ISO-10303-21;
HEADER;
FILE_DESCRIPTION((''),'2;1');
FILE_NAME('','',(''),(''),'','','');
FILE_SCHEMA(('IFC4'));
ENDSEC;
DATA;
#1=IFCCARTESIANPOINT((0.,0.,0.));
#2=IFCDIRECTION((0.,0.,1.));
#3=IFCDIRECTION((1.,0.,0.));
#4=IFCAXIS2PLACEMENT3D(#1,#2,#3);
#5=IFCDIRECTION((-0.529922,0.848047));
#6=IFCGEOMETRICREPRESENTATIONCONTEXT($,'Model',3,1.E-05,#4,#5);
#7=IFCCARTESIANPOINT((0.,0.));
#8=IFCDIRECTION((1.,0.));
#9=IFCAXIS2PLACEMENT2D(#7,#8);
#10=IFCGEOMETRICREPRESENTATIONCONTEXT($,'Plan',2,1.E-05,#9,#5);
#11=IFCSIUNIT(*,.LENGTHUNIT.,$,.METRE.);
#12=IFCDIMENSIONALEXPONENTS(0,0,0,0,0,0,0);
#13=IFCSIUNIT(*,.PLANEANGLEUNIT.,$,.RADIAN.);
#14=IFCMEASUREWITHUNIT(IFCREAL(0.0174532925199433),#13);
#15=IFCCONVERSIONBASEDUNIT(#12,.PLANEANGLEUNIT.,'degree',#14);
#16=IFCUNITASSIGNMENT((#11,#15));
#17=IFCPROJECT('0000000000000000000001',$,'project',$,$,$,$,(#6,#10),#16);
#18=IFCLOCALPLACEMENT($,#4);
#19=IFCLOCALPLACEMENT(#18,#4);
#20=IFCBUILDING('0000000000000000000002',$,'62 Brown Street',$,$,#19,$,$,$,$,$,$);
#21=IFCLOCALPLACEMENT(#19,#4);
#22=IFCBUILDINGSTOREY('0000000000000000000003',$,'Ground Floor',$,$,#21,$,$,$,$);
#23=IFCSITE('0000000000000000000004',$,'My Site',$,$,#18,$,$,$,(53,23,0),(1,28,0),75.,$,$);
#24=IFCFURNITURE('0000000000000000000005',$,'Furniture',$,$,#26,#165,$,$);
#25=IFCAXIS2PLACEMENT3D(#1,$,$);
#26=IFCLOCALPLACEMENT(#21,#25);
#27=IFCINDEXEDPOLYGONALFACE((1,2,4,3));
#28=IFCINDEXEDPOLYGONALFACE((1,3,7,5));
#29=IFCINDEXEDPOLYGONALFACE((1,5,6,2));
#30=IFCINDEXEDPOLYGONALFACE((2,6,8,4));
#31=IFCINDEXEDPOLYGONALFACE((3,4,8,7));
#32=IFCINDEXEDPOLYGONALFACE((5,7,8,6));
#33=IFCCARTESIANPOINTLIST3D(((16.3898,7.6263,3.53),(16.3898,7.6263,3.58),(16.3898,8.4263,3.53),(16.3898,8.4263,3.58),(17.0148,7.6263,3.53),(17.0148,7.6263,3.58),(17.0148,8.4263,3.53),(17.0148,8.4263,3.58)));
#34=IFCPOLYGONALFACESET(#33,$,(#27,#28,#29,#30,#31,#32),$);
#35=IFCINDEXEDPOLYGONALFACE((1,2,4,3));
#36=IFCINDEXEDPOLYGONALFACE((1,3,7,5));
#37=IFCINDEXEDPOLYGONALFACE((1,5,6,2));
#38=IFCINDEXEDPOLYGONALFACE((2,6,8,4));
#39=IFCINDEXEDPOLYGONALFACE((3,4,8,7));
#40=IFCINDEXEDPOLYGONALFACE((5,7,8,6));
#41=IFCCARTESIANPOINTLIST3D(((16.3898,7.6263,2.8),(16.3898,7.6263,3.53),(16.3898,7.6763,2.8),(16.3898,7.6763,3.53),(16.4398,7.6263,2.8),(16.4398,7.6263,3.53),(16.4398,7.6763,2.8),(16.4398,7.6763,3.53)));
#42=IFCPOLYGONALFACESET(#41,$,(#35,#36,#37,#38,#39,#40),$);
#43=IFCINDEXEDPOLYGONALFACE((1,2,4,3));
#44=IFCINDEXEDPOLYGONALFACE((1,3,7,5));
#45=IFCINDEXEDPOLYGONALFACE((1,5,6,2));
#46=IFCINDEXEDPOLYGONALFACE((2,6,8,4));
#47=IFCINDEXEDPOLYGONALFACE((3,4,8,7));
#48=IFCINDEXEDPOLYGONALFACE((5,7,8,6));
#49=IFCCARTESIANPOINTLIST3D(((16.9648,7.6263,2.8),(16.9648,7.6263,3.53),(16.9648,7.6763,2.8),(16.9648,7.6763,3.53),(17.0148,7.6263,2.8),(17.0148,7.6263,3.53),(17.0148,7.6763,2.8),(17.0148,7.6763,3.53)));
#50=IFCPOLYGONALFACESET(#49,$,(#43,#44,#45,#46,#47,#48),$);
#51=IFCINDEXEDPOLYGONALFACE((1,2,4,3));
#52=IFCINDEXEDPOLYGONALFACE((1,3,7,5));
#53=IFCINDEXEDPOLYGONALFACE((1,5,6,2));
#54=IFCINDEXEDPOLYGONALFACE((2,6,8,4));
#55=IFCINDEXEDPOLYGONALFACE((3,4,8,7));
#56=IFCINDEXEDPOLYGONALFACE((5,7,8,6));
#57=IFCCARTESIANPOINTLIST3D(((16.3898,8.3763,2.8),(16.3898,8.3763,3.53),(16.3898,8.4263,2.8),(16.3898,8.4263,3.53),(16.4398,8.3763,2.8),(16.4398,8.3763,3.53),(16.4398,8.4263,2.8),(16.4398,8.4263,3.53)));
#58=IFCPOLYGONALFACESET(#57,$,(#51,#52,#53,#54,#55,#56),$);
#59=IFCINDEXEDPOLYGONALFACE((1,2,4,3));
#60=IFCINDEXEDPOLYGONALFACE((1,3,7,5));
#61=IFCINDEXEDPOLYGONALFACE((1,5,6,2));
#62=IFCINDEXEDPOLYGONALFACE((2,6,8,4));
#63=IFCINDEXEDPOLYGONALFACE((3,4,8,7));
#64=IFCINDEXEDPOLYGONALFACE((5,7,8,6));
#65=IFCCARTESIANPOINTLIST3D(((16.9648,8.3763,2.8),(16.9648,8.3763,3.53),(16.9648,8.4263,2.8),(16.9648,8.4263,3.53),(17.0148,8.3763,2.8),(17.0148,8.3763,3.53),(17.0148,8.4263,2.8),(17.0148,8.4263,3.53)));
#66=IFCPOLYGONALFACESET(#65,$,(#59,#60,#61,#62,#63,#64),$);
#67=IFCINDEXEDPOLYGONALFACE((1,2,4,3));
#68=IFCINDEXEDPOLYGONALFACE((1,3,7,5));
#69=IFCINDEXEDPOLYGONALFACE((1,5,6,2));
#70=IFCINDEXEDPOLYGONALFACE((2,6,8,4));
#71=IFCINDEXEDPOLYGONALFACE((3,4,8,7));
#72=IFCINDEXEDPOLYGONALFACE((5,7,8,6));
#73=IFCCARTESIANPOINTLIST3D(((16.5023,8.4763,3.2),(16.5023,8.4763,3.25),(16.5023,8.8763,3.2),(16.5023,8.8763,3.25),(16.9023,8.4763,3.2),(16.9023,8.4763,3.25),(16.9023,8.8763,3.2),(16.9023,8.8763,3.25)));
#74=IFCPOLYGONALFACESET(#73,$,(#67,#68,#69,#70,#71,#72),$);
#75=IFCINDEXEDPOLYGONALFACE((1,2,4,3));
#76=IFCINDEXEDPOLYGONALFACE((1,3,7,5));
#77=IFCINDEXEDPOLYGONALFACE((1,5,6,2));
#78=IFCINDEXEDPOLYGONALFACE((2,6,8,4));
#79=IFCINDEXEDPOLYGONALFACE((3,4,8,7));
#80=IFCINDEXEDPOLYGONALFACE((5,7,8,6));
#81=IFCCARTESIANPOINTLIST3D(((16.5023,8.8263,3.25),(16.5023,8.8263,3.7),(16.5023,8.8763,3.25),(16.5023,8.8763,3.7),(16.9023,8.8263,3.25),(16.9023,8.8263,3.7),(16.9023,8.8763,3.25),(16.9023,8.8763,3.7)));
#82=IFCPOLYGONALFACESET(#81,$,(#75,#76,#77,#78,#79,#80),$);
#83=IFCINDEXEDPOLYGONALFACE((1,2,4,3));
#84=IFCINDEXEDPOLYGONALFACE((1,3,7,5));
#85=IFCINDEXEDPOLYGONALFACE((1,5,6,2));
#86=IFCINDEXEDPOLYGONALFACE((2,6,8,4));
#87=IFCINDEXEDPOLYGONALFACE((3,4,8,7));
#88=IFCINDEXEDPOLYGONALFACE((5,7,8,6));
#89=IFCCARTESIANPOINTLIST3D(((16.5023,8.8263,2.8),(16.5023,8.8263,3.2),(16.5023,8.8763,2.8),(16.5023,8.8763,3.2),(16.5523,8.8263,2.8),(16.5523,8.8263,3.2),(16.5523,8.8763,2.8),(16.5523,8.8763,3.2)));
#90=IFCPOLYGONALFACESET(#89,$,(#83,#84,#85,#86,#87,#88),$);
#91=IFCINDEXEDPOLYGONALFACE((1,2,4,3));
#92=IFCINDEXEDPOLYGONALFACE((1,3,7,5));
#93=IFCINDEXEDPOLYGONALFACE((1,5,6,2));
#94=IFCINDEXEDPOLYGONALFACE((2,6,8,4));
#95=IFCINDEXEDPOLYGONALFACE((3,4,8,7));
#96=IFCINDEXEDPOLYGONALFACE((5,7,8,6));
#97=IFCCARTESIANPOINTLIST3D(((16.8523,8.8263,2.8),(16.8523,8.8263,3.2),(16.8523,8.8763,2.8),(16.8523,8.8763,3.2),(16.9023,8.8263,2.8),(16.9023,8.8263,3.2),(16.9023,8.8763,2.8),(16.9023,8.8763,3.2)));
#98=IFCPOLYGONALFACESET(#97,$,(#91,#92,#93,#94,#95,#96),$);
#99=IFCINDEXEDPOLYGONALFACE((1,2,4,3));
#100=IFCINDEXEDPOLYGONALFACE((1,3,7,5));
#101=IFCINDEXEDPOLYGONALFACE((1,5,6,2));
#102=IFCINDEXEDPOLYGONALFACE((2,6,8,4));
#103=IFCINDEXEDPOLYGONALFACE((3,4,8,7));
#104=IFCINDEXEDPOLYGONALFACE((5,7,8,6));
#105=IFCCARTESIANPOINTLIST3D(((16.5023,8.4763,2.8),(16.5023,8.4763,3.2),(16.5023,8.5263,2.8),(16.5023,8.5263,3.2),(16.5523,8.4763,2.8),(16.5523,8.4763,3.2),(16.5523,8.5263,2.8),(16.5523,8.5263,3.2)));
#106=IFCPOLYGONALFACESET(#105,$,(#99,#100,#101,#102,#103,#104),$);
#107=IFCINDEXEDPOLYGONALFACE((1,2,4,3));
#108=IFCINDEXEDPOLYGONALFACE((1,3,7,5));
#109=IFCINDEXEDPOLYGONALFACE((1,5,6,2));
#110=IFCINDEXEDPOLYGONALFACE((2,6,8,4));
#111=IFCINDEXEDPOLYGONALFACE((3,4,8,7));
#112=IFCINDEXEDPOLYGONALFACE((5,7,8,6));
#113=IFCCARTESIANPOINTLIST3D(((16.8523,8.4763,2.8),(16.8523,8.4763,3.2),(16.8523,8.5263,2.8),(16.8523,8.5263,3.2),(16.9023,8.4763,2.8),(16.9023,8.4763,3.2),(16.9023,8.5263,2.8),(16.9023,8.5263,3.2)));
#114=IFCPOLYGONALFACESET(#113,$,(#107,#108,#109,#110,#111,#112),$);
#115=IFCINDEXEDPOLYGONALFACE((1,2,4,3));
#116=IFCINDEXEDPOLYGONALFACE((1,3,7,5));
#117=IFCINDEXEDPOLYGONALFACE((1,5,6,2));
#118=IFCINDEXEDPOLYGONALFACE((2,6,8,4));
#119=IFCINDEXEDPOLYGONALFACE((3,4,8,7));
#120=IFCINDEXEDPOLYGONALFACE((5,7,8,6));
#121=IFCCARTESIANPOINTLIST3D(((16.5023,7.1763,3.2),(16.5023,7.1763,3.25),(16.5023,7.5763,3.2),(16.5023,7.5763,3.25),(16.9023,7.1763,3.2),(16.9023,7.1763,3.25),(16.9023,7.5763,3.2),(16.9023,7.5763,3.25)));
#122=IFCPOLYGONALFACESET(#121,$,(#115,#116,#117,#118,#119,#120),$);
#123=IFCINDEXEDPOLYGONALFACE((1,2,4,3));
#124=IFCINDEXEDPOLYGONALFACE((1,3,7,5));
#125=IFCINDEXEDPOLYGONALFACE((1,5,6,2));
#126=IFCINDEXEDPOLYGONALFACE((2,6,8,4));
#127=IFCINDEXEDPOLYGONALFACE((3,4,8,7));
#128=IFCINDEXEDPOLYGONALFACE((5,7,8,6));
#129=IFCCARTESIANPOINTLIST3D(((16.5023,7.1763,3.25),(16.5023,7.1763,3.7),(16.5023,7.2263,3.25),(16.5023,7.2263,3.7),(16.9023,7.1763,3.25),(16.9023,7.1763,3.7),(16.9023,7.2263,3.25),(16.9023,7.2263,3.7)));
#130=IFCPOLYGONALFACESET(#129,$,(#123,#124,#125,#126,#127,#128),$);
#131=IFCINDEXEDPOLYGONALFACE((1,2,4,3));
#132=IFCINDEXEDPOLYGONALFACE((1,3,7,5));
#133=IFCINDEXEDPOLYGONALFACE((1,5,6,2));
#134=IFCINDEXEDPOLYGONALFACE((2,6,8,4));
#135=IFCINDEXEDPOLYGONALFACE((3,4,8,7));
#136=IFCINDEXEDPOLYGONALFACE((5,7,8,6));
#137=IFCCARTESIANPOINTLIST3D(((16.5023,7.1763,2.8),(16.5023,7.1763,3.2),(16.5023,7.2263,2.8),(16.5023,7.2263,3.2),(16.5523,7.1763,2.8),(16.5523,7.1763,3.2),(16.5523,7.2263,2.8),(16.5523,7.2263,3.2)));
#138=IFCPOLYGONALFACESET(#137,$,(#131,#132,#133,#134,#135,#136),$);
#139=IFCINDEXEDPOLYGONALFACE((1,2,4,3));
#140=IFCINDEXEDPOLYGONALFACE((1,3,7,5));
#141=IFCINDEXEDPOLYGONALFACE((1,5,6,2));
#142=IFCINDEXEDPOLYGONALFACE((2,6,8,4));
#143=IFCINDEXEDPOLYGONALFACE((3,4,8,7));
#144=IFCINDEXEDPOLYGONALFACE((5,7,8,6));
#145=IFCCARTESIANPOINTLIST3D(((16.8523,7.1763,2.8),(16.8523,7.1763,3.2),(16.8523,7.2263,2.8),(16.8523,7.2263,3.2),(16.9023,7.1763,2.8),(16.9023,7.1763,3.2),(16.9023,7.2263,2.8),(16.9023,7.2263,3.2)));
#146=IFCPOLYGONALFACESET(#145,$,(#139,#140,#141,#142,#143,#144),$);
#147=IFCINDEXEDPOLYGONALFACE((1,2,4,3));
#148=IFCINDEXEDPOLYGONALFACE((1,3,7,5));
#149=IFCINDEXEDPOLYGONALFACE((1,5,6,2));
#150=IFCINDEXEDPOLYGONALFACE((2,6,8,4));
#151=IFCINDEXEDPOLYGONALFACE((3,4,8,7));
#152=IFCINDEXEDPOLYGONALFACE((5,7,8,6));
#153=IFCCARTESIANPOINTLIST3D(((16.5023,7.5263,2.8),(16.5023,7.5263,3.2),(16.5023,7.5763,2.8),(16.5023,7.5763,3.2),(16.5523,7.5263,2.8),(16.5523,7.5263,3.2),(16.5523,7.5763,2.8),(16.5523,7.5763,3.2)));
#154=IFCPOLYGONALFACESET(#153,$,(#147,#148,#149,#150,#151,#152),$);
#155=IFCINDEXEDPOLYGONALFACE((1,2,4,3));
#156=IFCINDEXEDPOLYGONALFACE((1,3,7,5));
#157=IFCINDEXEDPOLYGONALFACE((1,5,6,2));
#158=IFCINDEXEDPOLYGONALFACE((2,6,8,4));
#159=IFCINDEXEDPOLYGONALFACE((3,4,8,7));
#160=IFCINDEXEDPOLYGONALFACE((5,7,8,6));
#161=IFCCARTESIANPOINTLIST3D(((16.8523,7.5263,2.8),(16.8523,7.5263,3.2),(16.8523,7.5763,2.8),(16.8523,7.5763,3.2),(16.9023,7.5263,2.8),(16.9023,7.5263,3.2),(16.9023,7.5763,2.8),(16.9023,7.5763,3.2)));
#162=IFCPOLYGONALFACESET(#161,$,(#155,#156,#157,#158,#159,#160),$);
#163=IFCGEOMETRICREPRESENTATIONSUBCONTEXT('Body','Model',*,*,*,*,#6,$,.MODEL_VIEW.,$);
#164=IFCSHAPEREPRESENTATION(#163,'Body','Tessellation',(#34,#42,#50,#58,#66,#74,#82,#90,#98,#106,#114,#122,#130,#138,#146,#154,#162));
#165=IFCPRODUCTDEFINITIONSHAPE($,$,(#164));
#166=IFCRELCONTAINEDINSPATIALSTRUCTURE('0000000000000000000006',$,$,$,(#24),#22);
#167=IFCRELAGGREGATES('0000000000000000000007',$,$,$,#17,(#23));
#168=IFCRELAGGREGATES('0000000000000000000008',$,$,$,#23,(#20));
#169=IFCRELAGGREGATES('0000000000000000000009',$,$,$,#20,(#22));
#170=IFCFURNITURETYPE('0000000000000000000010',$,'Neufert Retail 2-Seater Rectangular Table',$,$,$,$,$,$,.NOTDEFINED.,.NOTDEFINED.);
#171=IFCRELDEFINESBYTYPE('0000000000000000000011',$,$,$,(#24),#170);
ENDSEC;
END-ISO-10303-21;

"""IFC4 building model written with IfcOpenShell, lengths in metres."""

from ifc_helpers import new_model, entity, si_unit, converted_unit, direction, frame, origin_with_axes, origin_2d_with_axis, place, context, subcontext, project, spatial, line, indexed_curve, outline, extrude, shape, source, transform, mapped, type_object, type_shapes, element, save


model = new_model("IFC4")

# Units and contexts
model_context = context("Model", 3, precision=1e-05, world=origin_with_axes(), true_north=direction((-0.529922, 0.848047)))
plan_context = context("Plan", 2, precision=1e-05, world=origin_2d_with_axis(), true_north=direction((-0.529922, 0.848047)))
body_context_1 = subcontext(model_context, "Body", "Model", "MODEL_VIEW")
body_context_2 = subcontext(plan_context, "Body", "Plan", "PLAN_VIEW")
ifc_project = project(units=[si_unit("LENGTHUNIT", "METRE"), converted_unit("PLANEANGLEUNIT", "degree", entity("IfcReal", 0.0174532925199433), si_unit("PLANEANGLEUNIT", "RADIAN"), dimensions=[0, 0, 0, 0, 0, 0, 0])], contexts=[model_context, plan_context])

# Site, building, storey
site_placement = place(None, origin_with_axes())
site = spatial("IfcSite", under=ifc_project, at=site_placement, Name="My Site", RefLatitude=(53, 23, 0), RefLongitude=(1, 28, 0), RefElevation=75.0)
building_placement = place(site_placement, origin_with_axes())
building = spatial("IfcBuilding", under=site, at=building_placement, Name="62 Brown Street")
storey_placement = place(building_placement, origin_with_axes())
storey = spatial("IfcBuildingStorey", under=building, at=storey_placement, Name="Ground Floor")

# Furniture
furniture_type_1 = type_object("IfcFurnitureType", Name="Neufert Retail 2-Seater Rectangular Table", AssemblyPlace="NOTDEFINED", PredefinedType="NOTDEFINED")
shared_shape_1 = source(origin_with_axes(), body_context_1, "Body", "SweptSolid", [
    extrude(outline(indexed_curve([(0.0, 0.0), (0.625, 0.0), (0.625, 0.8), (0.0, 0.8)], segments=[line(1, 2, 3, 4, 1)])), frame((-0.3125, -0.4, 0.73), z_axis=(0.0, 0.0, 1.0), x_axis=(1.0, 0.0, 0.0)), (0.0, 0.0, 1.0), 0.05),
    extrude(outline(indexed_curve([(0.0, 0.0), (0.05, 0.0), (0.05, 0.05), (0.0, 0.05)], segments=[line(1, 2, 3, 4, 1)])), frame((-0.3125, -0.4, 0.0), z_axis=(0.0, 0.0, 1.0), x_axis=(1.0, 0.0, 0.0)), (0.0, 0.0, 1.0), 0.73),
    extrude(outline(indexed_curve([(0.625, 0.0), (0.575, 0.0), (0.575, 0.05), (0.625, 0.05)], segments=[line(1, 2, 3, 4, 1)])), frame((-0.3125, -0.4, 0.0), z_axis=(0.0, 0.0, 1.0), x_axis=(1.0, 0.0, 0.0)), (0.0, 0.0, 1.0), 0.73),
    extrude(outline(indexed_curve([(0.0, 0.8), (0.05, 0.8), (0.05, 0.75), (0.0, 0.75)], segments=[line(1, 2, 3, 4, 1)])), frame((-0.3125, -0.4, 0.0), z_axis=(0.0, 0.0, 1.0), x_axis=(1.0, 0.0, 0.0)), (0.0, 0.0, 1.0), 0.73),
    extrude(outline(indexed_curve([(0.625, 0.8), (0.575, 0.8), (0.575, 0.75), (0.625, 0.75)], segments=[line(1, 2, 3, 4, 1)])), frame((-0.3125, -0.4, 0.0), z_axis=(0.0, 0.0, 1.0), x_axis=(1.0, 0.0, 0.0)), (0.0, 0.0, 1.0), 0.73),
    extrude(outline(indexed_curve([(-0.2, 0.0), (0.2, 0.0), (0.2, -0.4), (-0.2, -0.4)], segments=[line(1, 2, 3, 4, 1)])), frame((0.0, 0.85, 0.45), z_axis=(0.0, 0.0, 1.0), x_axis=(1.0, 0.0, 0.0)), (0.0, 0.0, -1.0), 0.05),
    extrude(outline(indexed_curve([(-0.2, 0.0), (0.2, 0.0), (0.2, -0.05), (-0.2, -0.05)], segments=[line(1, 2, 3, 4, 1)])), frame((0.0, 0.85, 0.9), z_axis=(0.0, 0.0, 1.0), x_axis=(1.0, 0.0, 0.0)), (0.0, 0.0, -1.0), 0.45),
    extrude(outline(indexed_curve([(-0.2, 0.0), (-0.15, 0.0), (-0.15, -0.05), (-0.2, -0.05)], segments=[line(1, 2, 3, 4, 1)])), frame((0.0, 0.85, 0.0), z_axis=(0.0, 0.0, 1.0), x_axis=(1.0, 0.0, 0.0)), (0.0, 0.0, 1.0), 0.4),
    extrude(outline(indexed_curve([(0.2, 0.0), (0.15, 0.0), (0.15, -0.05), (0.2, -0.05)], segments=[line(1, 2, 3, 4, 1)])), frame((0.0, 0.85, 0.0), z_axis=(0.0, 0.0, 1.0), x_axis=(1.0, 0.0, 0.0)), (0.0, 0.0, 1.0), 0.4),
    extrude(outline(indexed_curve([(-0.2, -0.4), (-0.15, -0.4), (-0.15, -0.35), (-0.2, -0.35)], segments=[line(1, 2, 3, 4, 1)])), frame((0.0, 0.85, 0.0), z_axis=(0.0, 0.0, 1.0), x_axis=(1.0, 0.0, 0.0)), (0.0, 0.0, 1.0), 0.4),
    extrude(outline(indexed_curve([(0.2, -0.4), (0.15, -0.4), (0.15, -0.35), (0.2, -0.35)], segments=[line(1, 2, 3, 4, 1)])), frame((0.0, 0.85, 0.0), z_axis=(0.0, 0.0, 1.0), x_axis=(1.0, 0.0, 0.0)), (0.0, 0.0, 1.0), 0.4),
    extrude(outline(indexed_curve([(-0.2, 0.0), (0.2, 0.0), (0.2, 0.4), (-0.2, 0.4)], segments=[line(1, 2, 3, 4, 1)])), frame((0.0, -0.85, 0.45), z_axis=(0.0, 0.0, 1.0), x_axis=(1.0, 0.0, 0.0)), (0.0, 0.0, -1.0), 0.05),
    extrude(outline(indexed_curve([(-0.2, 0.0), (0.2, 0.0), (0.2, 0.05), (-0.2, 0.05)], segments=[line(1, 2, 3, 4, 1)])), frame((0.0, -0.85, 0.9), z_axis=(0.0, 0.0, 1.0), x_axis=(1.0, 0.0, 0.0)), (0.0, 0.0, -1.0), 0.45),
    extrude(outline(indexed_curve([(-0.2, 0.0), (-0.15, 0.0), (-0.15, 0.05), (-0.2, 0.05)], segments=[line(1, 2, 3, 4, 1)])), frame((0.0, -0.85, 0.0), z_axis=(0.0, 0.0, 1.0), x_axis=(1.0, 0.0, 0.0)), (0.0, 0.0, 1.0), 0.4),
    extrude(outline(indexed_curve([(0.2, 0.0), (0.15, 0.0), (0.15, 0.05), (0.2, 0.05)], segments=[line(1, 2, 3, 4, 1)])), frame((0.0, -0.85, 0.0), z_axis=(0.0, 0.0, 1.0), x_axis=(1.0, 0.0, 0.0)), (0.0, 0.0, 1.0), 0.4),
    extrude(outline(indexed_curve([(-0.2, 0.4), (-0.15, 0.4), (-0.15, 0.35), (-0.2, 0.35)], segments=[line(1, 2, 3, 4, 1)])), frame((0.0, -0.85, 0.0), z_axis=(0.0, 0.0, 1.0), x_axis=(1.0, 0.0, 0.0)), (0.0, 0.0, 1.0), 0.4),
    extrude(outline(indexed_curve([(0.2, 0.4), (0.15, 0.4), (0.15, 0.35), (0.2, 0.35)], segments=[line(1, 2, 3, 4, 1)])), frame((0.0, -0.85, 0.0), z_axis=(0.0, 0.0, 1.0), x_axis=(1.0, 0.0, 0.0)), (0.0, 0.0, 1.0), 0.4),
])
shared_shape_2 = source(origin_with_axes(), body_context_2, "Body", "Curve2D", [
    entity("IfcIndexedPolyCurve", entity("IfcCartesianPointList2D", [[-0.3125, -0.4], [0.3125, -0.4], [0.3125, 0.4], [-0.3125, 0.4]]), [entity("IfcLineIndex", [1, 2, 3, 4, 1])]),
    entity("IfcIndexedPolyCurve", entity("IfcCartesianPointList2D", [[-0.2, 0.45], [0.2, 0.45]])),
    entity("IfcIndexedPolyCurve", entity("IfcCartesianPointList2D", [[-0.2, 0.45], [-0.2, 0.65], [-0.1414, 0.7914], [0.0, 0.85], [0.1414, 0.7914], [0.2, 0.65], [0.2, 0.45]]), [entity("IfcLineIndex", [1, 2]), entity("IfcArcIndex", [2, 3, 4]), entity("IfcArcIndex", [4, 5, 6]), entity("IfcLineIndex", [6, 7])]),
    entity("IfcIndexedPolyCurve", entity("IfcCartesianPointList2D", [[-0.16, 0.45], [-0.16, 0.65], [-0.1131, 0.7631], [0.0, 0.81], [0.1131, 0.7631], [0.16, 0.65], [0.16, 0.45]]), [entity("IfcLineIndex", [1, 2]), entity("IfcArcIndex", [2, 3, 4]), entity("IfcArcIndex", [4, 5, 6]), entity("IfcLineIndex", [6, 7])]),
    entity("IfcIndexedPolyCurve", entity("IfcCartesianPointList2D", [[-0.2, -0.45], [0.2, -0.45]])),
    entity("IfcIndexedPolyCurve", entity("IfcCartesianPointList2D", [[-0.2, -0.45], [-0.2, -0.65], [-0.1414, -0.7914], [0.0, -0.85], [0.1414, -0.7914], [0.2, -0.65], [0.2, -0.45]]), [entity("IfcLineIndex", [1, 2]), entity("IfcArcIndex", [2, 3, 4]), entity("IfcArcIndex", [4, 5, 6]), entity("IfcLineIndex", [6, 7])]),
    entity("IfcIndexedPolyCurve", entity("IfcCartesianPointList2D", [[-0.16, -0.45], [-0.16, -0.65], [-0.1131, -0.7631], [0.0, -0.81], [0.1131, -0.7631], [0.16, -0.65], [0.16, -0.45]]), [entity("IfcLineIndex", [1, 2]), entity("IfcArcIndex", [2, 3, 4]), entity("IfcArcIndex", [4, 5, 6]), entity("IfcLineIndex", [6, 7])]),
])
type_shapes(furniture_type_1, [shared_shape_1, shared_shape_2])
furniture_1_placement = place(storey_placement, frame((16.7023, 8.0263, 2.8), z_axis=(0.0, 0.0, 1.0), x_axis=(1.0, 0.0, 0.0)))
element("IfcFurniture", 1, at=furniture_1_placement, inside=storey, type_object=furniture_type_1, Name="Furniture", shapes=[
    shape(body_context_1, "Body", "MappedRepresentation", [mapped(shared_shape_1, transform((0.0, 0.0, 0.0), x_axis=(1.0, 0.0, 0.0), y_axis=(0.0, 1.0, 0.0), z_axis=(0.0, 0.0, 1.0), scale=1.0))]),
    shape(body_context_2, "Body", "MappedRepresentation", [mapped(shared_shape_2, transform((0.0, 0.0, 0.0), x_axis=(1.0, 0.0, 0.0), y_axis=(0.0, 1.0, 0.0), z_axis=(0.0, 0.0, 1.0), scale=1.0))]),
])

save(model, "model.ifc")
